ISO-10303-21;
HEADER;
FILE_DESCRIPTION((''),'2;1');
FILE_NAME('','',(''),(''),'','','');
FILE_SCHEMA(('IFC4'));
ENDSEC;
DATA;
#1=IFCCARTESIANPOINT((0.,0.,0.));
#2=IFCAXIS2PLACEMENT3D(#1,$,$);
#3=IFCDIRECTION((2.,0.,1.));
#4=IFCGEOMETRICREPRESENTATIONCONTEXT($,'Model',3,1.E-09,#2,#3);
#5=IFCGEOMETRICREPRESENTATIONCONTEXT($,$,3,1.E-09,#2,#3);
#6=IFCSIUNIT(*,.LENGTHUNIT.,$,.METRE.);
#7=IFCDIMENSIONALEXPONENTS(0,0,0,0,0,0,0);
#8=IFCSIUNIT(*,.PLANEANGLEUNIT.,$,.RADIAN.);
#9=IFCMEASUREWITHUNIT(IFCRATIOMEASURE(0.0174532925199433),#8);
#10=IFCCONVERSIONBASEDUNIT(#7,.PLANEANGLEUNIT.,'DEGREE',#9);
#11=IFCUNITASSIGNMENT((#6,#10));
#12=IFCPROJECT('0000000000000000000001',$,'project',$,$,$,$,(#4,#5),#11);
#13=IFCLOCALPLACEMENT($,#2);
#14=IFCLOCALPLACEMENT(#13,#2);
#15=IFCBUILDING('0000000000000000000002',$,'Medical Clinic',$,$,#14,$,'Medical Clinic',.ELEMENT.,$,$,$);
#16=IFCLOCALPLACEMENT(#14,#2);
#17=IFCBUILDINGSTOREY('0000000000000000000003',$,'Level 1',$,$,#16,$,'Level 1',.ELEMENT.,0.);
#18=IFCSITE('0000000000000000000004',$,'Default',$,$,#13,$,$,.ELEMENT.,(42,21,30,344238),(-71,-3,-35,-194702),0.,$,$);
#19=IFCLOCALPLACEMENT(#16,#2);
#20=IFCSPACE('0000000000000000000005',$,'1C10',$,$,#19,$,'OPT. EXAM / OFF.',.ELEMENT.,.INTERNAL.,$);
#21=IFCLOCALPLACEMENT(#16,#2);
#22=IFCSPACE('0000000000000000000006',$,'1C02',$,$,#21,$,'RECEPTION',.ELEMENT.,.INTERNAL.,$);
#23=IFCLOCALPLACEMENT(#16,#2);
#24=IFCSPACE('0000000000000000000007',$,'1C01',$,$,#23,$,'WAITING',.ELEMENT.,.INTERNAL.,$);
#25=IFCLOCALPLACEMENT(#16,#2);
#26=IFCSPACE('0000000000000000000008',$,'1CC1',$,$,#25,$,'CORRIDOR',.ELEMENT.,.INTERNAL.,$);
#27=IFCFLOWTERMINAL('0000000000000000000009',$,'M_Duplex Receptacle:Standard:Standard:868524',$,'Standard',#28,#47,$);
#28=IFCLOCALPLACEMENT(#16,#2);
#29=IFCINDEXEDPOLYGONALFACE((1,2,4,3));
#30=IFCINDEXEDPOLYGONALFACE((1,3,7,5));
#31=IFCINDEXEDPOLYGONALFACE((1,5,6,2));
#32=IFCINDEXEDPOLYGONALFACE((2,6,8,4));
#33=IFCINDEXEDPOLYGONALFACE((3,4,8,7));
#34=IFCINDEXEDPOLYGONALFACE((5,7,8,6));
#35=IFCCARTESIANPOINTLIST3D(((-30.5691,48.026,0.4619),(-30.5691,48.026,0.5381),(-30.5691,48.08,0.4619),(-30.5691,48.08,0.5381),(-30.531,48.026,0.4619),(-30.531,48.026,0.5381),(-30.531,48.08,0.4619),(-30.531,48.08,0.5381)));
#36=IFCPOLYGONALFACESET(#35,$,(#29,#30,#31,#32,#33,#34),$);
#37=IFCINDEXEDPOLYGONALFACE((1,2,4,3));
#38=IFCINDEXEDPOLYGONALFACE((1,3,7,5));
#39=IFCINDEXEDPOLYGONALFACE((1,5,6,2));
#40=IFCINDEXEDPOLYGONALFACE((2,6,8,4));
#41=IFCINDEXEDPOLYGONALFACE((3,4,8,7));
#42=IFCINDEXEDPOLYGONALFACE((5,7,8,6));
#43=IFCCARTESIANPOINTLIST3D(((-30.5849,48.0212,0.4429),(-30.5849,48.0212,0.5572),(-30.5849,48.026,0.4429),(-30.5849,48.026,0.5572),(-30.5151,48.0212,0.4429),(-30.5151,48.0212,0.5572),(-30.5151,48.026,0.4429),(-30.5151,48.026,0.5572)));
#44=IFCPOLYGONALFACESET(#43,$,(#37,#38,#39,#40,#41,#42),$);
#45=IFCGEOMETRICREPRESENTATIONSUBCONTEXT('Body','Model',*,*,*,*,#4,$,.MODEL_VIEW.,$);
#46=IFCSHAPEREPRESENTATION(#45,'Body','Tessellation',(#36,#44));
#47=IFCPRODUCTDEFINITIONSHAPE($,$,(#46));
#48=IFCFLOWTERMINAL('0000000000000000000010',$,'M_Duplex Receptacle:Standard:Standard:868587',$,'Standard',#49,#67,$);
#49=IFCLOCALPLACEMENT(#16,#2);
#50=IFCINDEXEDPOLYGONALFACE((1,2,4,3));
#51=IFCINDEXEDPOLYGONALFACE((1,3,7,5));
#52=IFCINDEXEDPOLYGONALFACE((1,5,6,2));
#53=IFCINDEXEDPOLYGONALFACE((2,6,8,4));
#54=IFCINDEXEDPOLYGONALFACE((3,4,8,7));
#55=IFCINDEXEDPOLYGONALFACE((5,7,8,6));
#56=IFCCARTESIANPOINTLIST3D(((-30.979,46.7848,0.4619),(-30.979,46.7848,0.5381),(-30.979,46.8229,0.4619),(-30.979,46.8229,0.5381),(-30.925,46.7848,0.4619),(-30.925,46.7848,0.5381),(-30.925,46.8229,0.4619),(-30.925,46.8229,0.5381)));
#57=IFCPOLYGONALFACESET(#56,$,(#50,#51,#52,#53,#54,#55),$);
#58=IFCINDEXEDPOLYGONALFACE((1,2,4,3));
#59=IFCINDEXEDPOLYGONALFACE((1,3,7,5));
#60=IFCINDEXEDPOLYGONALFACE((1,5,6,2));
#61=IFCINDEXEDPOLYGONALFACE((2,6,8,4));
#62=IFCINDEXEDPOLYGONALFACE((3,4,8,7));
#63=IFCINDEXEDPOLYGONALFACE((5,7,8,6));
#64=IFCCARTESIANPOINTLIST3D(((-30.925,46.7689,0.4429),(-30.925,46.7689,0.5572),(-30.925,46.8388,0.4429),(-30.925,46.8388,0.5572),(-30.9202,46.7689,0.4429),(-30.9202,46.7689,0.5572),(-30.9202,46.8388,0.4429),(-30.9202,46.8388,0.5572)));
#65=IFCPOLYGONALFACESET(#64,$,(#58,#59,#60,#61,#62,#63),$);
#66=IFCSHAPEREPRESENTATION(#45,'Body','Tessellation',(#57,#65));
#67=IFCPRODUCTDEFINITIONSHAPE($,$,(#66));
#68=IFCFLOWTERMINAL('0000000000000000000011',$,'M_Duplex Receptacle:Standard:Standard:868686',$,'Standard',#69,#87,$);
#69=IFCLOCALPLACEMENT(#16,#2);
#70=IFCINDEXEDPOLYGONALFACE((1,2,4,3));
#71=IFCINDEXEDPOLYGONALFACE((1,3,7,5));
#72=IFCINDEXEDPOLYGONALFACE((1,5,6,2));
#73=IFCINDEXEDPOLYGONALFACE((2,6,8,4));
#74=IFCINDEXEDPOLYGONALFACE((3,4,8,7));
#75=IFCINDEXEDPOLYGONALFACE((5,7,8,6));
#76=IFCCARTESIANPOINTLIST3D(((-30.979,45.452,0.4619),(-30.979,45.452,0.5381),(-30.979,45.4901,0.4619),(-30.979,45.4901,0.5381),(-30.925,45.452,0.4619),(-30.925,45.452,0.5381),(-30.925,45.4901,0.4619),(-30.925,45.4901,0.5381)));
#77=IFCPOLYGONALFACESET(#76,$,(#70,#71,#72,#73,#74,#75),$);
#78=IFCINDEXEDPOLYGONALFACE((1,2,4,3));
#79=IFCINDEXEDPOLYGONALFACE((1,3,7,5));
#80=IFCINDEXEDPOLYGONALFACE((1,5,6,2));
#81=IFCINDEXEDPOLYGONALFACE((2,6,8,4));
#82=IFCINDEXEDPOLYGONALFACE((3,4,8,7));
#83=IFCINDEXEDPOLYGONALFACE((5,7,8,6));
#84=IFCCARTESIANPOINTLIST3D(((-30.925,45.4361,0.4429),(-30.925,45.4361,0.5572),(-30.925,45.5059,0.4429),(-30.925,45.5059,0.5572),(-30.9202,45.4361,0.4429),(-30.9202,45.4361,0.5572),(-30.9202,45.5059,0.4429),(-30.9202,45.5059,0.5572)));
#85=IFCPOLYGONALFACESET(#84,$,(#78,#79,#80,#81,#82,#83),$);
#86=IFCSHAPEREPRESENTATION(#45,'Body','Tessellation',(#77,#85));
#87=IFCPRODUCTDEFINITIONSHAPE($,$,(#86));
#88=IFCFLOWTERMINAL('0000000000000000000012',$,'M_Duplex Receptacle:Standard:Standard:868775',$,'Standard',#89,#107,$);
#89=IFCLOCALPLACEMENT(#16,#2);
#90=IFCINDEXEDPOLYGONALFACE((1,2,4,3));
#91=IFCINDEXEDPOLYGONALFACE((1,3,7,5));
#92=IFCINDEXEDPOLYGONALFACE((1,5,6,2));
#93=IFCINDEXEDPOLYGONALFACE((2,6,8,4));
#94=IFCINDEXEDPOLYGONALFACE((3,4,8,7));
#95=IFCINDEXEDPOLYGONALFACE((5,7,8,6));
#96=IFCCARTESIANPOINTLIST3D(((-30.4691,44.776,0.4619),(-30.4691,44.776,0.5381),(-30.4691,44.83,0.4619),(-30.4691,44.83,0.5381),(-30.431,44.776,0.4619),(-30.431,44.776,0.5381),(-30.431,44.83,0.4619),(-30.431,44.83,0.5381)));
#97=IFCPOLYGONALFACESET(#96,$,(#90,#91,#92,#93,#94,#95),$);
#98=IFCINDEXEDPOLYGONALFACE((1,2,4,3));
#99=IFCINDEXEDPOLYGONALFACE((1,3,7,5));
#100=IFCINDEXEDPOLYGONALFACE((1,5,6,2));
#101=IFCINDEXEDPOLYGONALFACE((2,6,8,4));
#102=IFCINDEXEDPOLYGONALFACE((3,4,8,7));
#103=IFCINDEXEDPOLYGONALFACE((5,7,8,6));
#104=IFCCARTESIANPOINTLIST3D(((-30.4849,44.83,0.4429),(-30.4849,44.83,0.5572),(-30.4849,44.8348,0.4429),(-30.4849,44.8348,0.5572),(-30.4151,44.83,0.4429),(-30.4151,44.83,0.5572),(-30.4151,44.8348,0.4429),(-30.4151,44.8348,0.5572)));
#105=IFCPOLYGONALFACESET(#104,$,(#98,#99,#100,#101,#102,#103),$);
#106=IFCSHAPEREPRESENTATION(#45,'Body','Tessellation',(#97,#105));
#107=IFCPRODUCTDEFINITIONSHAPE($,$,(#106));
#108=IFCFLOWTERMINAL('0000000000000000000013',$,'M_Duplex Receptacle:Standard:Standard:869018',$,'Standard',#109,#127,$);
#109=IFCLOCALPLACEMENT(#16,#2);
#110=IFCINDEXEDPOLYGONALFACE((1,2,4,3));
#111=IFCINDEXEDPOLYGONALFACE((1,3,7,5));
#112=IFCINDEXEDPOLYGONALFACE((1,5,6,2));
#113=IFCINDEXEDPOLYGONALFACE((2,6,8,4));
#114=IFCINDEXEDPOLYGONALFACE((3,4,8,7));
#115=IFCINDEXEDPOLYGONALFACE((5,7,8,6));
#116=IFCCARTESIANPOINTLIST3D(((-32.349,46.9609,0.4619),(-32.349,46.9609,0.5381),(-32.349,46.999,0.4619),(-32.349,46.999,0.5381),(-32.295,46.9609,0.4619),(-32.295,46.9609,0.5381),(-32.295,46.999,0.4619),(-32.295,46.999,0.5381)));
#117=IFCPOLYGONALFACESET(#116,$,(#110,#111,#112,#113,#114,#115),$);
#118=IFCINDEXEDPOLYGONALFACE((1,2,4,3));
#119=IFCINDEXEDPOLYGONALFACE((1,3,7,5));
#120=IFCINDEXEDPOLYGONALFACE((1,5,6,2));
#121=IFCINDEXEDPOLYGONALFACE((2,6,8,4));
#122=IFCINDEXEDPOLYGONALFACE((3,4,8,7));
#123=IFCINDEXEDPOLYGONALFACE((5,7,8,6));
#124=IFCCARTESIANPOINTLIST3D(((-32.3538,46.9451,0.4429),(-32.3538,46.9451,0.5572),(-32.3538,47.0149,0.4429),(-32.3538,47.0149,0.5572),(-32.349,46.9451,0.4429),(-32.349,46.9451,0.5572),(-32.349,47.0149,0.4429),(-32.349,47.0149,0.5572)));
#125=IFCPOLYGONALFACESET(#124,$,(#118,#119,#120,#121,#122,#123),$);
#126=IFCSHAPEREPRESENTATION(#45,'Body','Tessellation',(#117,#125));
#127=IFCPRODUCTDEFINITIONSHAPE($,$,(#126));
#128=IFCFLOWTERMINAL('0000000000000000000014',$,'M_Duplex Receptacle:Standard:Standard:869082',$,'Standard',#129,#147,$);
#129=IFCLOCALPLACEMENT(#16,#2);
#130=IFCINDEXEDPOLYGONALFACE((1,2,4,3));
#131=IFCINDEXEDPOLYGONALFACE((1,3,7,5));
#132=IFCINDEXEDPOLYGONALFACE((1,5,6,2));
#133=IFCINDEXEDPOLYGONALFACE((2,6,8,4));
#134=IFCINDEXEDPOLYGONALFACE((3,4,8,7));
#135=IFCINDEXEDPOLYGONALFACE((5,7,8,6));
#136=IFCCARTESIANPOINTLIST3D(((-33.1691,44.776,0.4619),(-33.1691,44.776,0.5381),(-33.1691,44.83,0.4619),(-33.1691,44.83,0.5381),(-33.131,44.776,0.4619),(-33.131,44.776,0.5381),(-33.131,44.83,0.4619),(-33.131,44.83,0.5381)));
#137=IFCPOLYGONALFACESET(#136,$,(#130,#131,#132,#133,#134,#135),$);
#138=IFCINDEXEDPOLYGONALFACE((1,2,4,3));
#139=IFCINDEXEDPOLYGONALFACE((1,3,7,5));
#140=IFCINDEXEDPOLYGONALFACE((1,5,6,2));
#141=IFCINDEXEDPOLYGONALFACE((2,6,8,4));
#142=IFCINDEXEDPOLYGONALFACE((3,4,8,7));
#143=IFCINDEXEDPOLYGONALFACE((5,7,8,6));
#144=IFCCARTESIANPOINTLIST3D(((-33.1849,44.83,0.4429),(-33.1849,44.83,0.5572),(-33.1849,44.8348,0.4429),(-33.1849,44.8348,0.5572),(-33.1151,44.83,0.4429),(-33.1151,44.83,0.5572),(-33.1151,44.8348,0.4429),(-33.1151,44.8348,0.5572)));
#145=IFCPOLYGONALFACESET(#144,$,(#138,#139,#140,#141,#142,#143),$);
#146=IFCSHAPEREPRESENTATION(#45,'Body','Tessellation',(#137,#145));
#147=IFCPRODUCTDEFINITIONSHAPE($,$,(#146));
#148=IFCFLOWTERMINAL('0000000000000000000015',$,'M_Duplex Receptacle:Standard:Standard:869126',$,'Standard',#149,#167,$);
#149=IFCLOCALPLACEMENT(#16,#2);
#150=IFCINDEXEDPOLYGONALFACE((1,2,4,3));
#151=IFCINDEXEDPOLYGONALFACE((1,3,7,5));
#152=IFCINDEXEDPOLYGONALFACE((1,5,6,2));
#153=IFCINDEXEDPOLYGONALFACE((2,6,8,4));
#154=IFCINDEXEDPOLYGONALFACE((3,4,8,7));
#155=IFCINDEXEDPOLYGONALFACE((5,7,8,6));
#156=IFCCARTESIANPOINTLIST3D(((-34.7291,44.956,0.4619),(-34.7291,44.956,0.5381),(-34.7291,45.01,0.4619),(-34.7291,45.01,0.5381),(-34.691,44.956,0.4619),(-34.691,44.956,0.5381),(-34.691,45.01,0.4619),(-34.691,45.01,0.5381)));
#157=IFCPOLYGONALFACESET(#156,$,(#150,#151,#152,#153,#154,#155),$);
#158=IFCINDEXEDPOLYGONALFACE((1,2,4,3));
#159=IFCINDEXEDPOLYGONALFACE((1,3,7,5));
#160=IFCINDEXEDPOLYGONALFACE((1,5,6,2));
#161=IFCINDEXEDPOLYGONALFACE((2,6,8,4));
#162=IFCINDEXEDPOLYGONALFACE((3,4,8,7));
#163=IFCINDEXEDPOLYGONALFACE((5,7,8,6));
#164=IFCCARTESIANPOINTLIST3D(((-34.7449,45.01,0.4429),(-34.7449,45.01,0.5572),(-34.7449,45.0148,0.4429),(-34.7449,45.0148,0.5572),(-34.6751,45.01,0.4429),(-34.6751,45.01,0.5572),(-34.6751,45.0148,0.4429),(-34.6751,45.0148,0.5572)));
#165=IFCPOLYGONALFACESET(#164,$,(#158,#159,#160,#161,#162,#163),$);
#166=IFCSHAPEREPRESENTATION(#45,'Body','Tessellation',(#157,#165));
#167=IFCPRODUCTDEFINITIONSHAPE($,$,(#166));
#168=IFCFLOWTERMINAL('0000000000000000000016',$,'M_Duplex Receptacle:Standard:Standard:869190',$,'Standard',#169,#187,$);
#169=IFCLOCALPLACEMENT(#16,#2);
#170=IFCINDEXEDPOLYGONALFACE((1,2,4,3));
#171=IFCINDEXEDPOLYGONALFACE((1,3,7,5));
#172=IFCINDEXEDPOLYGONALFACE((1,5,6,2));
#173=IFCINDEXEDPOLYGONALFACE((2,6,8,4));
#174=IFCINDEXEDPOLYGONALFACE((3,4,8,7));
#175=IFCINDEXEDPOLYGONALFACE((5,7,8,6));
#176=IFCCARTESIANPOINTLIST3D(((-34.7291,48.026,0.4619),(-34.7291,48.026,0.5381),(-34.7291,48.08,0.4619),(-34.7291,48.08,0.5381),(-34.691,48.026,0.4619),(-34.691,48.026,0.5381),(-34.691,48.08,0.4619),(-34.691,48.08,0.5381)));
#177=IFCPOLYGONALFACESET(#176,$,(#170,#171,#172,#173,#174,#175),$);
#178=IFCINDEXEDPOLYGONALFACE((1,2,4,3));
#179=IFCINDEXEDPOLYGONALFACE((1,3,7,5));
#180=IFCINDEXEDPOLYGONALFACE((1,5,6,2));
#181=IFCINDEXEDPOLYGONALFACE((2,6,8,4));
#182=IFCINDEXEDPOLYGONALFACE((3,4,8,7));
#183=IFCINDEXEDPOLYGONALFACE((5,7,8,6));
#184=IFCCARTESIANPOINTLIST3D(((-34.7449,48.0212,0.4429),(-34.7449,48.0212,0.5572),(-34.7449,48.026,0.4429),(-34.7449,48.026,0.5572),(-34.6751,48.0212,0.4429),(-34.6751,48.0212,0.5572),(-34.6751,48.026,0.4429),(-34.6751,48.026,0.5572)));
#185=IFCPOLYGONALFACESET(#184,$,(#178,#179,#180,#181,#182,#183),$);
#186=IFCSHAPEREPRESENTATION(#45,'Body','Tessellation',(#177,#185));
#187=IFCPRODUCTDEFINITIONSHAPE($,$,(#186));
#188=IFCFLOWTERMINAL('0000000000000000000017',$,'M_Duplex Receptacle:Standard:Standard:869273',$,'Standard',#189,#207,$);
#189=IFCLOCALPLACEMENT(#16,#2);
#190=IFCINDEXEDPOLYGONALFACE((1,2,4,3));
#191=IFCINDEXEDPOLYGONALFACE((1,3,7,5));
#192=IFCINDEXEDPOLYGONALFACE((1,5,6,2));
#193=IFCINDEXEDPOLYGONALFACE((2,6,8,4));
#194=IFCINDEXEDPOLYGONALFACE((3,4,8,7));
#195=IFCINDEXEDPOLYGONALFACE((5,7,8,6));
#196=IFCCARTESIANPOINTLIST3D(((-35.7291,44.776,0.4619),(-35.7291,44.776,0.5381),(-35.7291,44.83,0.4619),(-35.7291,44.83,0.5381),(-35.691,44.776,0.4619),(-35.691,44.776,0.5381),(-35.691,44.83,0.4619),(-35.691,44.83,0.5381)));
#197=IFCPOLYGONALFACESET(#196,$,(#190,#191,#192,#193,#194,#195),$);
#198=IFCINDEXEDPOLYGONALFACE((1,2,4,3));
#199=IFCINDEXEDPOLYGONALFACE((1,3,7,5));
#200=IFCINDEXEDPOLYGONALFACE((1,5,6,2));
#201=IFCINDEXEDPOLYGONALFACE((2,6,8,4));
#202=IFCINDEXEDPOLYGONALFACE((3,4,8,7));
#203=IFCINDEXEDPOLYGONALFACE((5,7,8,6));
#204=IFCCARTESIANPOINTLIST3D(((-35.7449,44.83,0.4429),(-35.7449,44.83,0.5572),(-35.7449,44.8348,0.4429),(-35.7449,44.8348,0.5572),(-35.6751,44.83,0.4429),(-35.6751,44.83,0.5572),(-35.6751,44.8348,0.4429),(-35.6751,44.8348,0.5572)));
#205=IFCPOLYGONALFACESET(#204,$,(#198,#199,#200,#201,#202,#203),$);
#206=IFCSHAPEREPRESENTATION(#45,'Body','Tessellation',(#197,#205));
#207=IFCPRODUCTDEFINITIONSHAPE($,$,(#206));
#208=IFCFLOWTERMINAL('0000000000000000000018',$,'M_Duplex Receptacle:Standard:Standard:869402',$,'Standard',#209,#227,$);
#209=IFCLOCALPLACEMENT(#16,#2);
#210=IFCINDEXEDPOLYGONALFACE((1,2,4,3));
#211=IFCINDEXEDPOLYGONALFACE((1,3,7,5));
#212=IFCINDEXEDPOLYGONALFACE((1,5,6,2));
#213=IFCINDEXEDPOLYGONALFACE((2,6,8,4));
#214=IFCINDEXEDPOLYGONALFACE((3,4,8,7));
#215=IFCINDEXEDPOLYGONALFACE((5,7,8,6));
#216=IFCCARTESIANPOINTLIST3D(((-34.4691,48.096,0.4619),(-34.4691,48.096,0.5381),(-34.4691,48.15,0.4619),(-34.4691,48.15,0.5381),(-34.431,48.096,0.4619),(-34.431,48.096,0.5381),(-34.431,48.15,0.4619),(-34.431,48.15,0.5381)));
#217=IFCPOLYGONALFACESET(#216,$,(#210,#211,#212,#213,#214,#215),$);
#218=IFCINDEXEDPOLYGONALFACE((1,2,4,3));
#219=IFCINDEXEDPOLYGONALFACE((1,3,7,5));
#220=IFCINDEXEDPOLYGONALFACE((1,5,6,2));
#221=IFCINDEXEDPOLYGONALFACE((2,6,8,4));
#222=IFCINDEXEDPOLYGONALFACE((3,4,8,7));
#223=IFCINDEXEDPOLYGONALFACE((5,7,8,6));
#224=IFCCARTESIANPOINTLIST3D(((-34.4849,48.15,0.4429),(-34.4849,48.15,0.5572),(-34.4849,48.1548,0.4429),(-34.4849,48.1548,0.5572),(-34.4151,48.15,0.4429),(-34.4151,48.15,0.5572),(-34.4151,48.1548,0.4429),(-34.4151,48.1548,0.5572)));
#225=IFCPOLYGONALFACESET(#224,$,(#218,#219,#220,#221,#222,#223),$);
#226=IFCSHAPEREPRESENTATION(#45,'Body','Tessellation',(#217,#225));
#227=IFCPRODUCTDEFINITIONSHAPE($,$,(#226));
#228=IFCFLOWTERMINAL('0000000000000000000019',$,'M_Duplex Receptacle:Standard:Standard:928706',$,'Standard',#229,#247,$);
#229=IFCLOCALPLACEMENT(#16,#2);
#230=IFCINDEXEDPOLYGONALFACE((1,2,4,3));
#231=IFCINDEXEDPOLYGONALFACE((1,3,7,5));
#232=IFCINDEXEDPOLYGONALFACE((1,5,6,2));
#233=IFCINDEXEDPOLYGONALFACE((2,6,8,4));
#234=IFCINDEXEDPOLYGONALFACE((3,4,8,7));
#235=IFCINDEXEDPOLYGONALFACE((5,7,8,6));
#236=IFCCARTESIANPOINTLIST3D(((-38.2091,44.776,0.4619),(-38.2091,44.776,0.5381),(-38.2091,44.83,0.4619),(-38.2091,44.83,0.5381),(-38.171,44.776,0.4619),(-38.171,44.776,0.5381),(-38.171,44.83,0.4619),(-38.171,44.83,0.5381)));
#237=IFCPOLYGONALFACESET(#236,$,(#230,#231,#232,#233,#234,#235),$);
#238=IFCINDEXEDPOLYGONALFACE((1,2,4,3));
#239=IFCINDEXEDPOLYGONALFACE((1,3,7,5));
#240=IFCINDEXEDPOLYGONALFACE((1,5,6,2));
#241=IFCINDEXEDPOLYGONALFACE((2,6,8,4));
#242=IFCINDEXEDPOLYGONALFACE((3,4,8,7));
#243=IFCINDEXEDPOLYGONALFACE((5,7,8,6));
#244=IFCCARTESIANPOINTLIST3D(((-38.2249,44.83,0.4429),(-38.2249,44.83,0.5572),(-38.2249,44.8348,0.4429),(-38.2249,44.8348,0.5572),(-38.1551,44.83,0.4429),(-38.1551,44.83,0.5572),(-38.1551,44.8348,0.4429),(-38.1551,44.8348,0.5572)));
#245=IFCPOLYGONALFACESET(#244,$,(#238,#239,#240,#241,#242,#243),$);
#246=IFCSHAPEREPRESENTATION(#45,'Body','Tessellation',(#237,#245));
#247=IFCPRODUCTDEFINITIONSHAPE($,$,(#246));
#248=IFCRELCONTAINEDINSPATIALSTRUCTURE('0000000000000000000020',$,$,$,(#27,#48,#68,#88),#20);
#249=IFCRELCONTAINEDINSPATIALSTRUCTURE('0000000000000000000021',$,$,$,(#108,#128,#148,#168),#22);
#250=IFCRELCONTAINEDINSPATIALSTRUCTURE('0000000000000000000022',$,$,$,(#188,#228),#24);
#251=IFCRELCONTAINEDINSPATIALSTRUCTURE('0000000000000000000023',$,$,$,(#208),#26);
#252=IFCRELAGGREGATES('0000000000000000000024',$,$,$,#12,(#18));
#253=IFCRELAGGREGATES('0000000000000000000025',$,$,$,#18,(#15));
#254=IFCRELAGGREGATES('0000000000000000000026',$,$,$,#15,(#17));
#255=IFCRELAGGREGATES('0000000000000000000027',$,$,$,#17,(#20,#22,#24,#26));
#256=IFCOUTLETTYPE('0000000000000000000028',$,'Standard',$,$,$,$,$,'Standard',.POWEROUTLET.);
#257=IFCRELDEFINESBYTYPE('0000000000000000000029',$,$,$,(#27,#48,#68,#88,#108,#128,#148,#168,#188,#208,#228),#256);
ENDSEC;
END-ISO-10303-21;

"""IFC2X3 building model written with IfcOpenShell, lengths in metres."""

from ifc_helpers import new_model, entity, si_unit, converted_unit, direction, frame, frame_2d, origin, origin_2d_with_axis, place, context, subcontext, project, spatial, rectangle, extrude, source, transform, mapped, type_object, type_shapes, element, save


model = new_model("IFC2X3")

# Units and contexts
model_context = context("Model", 3, precision=1e-09, world=origin(), true_north=direction((2.0, 0.0, 1.0)))
context_of_model = context(None, 3, precision=1e-09, world=origin(), true_north=direction((2.0, 0.0, 1.0)))
body_context = subcontext(model_context, "Body", "Model", "MODEL_VIEW")
ifc_project = project(units=[si_unit("LENGTHUNIT", "METRE"), converted_unit("PLANEANGLEUNIT", "DEGREE", entity("IfcRatioMeasure", 0.0174532925199433), si_unit("PLANEANGLEUNIT", "RADIAN"), dimensions=[0, 0, 0, 0, 0, 0, 0])], contexts=[model_context, context_of_model])

# Site, building, storey, space
site_placement = place(None, origin())
site = spatial("IfcSite", under=ifc_project, at=site_placement, Name="Default", CompositionType="ELEMENT", RefLatitude=(42, 21, 30, 344238), RefLongitude=(-71, -3, -35, -194702), RefElevation=0.0)
building_placement = place(site_placement, origin())
building = spatial("IfcBuilding", under=site, at=building_placement, Name="Medical Clinic", LongName="Medical Clinic", CompositionType="ELEMENT")
storey_placement = place(building_placement, origin())
storey = spatial("IfcBuildingStorey", under=building, at=storey_placement, Name="Level 1", LongName="Level 1", CompositionType="ELEMENT", Elevation=0.0)
space_1_placement = place(storey_placement, origin())
space_1 = spatial("IfcSpace", under=storey, at=space_1_placement, Name="1C10", LongName="OPT. EXAM / OFF.", CompositionType="ELEMENT", InteriorOrExteriorSpace="INTERNAL")

# Flow terminals
outlet_type_1 = type_object("IfcOutletType", Name="Standard", ElementType="Standard", PredefinedType="POWEROUTLET")
shared_shape_1 = source(origin(), body_context, "Body", "SweptSolid", [
    extrude(rectangle(XDim=0.0381, YDim=0.0762, at=origin_2d_with_axis()), frame((0.0, 0.0, -0.054), z_axis=(0.0, 0.0, 1.0), x_axis=(-1.0, 0.0, 0.0)), (0.0, 0.0, 1.0), 0.054),
    extrude(rectangle(XDim=0.0698, YDim=0.1143, at=frame_2d((0.0, 0.0), x_axis=(1.0, 0.0))), frame((0.0, 0.0, 0.0), z_axis=(0.0, 0.0, 1.0), x_axis=(-1.0, 0.0, 0.0)), (0.0, 0.0, 1.0), 0.0048),
])
type_shapes(outlet_type_1, [shared_shape_1])
for number, where, z_axis, x_axis, name in (
    (1, (-30.55, 48.026, 0.5), (0.0, -1.0, 0.0), (1.0, 0.0, 0.0), "M_Duplex Receptacle:Standard:Standard:868524"),
    (2, (-30.925, 46.8038, 0.5), (1.0, 0.0, 0.0), (0.0, 1.0, 0.0), "M_Duplex Receptacle:Standard:Standard:868587"),
    (3, (-30.925, 45.471, 0.5), (1.0, 0.0, 0.0), (0.0, 1.0, 0.0), "M_Duplex Receptacle:Standard:Standard:868686"),
    (4, (-30.45, 44.83, 0.5), (0.0, 1.0, 0.0), (-1.0, 0.0, 0.0), "M_Duplex Receptacle:Standard:Standard:868775"),
):
    element("IfcFlowTerminal", number, at=place(space_1_placement, frame(where, z_axis=z_axis, x_axis=x_axis)), inside=space_1, type_object=outlet_type_1, Name=name, ObjectType="Standard", context=body_context, shape_type="MappedRepresentation", body=[
        mapped(shared_shape_1, transform((0.0, 0.0, 0.0), scale=1.0)),
    ])

# Shared definitions
space_2_placement = place(storey_placement, origin())
space_2 = spatial("IfcSpace", under=storey, at=space_2_placement, Name="1C02", LongName="RECEPTION", CompositionType="ELEMENT", InteriorOrExteriorSpace="INTERNAL")

# Flow terminals
for number, where, z_axis, x_axis, name in (
    (5, (-32.349, 46.98, 0.5), (-1.0, 0.0, 0.0), (0.0, -1.0, 0.0), "M_Duplex Receptacle:Standard:Standard:869018"),
    (6, (-33.15, 44.83, 0.5), (0.0, 1.0, 0.0), (-1.0, 0.0, 0.0), "M_Duplex Receptacle:Standard:Standard:869082"),
    (7, (-34.71, 45.01, 0.5), (0.0, 1.0, 0.0), (-1.0, 0.0, 0.0), "M_Duplex Receptacle:Standard:Standard:869126"),
    (8, (-34.71, 48.026, 0.5), (0.0, -1.0, 0.0), (1.0, 0.0, 0.0), "M_Duplex Receptacle:Standard:Standard:869190"),
):
    element("IfcFlowTerminal", number, at=place(space_2_placement, frame(where, z_axis=z_axis, x_axis=x_axis)), inside=space_2, type_object=outlet_type_1, Name=name, ObjectType="Standard", context=body_context, shape_type="MappedRepresentation", body=[
        mapped(shared_shape_1, transform((0.0, 0.0, 0.0), scale=1.0)),
    ])

# Shared definitions
space_3_placement = place(storey_placement, origin())
space_3 = spatial("IfcSpace", under=storey, at=space_3_placement, Name="1C01", LongName="WAITING", CompositionType="ELEMENT", InteriorOrExteriorSpace="INTERNAL")

# Flow terminal
flow_terminal_1_placement = place(space_3_placement, frame((-35.71, 44.83, 0.5), z_axis=(0.0, 1.0, 0.0), x_axis=(-1.0, 0.0, 0.0)))
element("IfcFlowTerminal", 9, at=flow_terminal_1_placement, inside=space_3, type_object=outlet_type_1, Name="M_Duplex Receptacle:Standard:Standard:869273", ObjectType="Standard", context=body_context, shape_type="MappedRepresentation", body=[
    mapped(shared_shape_1, transform((0.0, 0.0, 0.0), scale=1.0)),
])

# Shared definitions
space_4_placement = place(storey_placement, origin())
space_4 = spatial("IfcSpace", under=storey, at=space_4_placement, Name="1CC1", LongName="CORRIDOR", CompositionType="ELEMENT", InteriorOrExteriorSpace="INTERNAL")

# Flow terminals
flow_terminal_2_placement = place(space_4_placement, frame((-34.45, 48.15, 0.5), z_axis=(0.0, 1.0, 0.0), x_axis=(-1.0, 0.0, 0.0)))
element("IfcFlowTerminal", 10, at=flow_terminal_2_placement, inside=space_4, type_object=outlet_type_1, Name="M_Duplex Receptacle:Standard:Standard:869402", ObjectType="Standard", context=body_context, shape_type="MappedRepresentation", body=[
    mapped(shared_shape_1, transform((0.0, 0.0, 0.0), scale=1.0)),
])
flow_terminal_3_placement = place(space_3_placement, frame((-38.19, 44.83, 0.5), z_axis=(0.0, 1.0, 0.0), x_axis=(-1.0, 0.0, 0.0)))
element("IfcFlowTerminal", 11, at=flow_terminal_3_placement, inside=space_3, type_object=outlet_type_1, Name="M_Duplex Receptacle:Standard:Standard:928706", ObjectType="Standard", context=body_context, shape_type="MappedRepresentation", body=[
    mapped(shared_shape_1, transform((0.0, 0.0, 0.0), scale=1.0)),
])

save(model, "model.ifc")
